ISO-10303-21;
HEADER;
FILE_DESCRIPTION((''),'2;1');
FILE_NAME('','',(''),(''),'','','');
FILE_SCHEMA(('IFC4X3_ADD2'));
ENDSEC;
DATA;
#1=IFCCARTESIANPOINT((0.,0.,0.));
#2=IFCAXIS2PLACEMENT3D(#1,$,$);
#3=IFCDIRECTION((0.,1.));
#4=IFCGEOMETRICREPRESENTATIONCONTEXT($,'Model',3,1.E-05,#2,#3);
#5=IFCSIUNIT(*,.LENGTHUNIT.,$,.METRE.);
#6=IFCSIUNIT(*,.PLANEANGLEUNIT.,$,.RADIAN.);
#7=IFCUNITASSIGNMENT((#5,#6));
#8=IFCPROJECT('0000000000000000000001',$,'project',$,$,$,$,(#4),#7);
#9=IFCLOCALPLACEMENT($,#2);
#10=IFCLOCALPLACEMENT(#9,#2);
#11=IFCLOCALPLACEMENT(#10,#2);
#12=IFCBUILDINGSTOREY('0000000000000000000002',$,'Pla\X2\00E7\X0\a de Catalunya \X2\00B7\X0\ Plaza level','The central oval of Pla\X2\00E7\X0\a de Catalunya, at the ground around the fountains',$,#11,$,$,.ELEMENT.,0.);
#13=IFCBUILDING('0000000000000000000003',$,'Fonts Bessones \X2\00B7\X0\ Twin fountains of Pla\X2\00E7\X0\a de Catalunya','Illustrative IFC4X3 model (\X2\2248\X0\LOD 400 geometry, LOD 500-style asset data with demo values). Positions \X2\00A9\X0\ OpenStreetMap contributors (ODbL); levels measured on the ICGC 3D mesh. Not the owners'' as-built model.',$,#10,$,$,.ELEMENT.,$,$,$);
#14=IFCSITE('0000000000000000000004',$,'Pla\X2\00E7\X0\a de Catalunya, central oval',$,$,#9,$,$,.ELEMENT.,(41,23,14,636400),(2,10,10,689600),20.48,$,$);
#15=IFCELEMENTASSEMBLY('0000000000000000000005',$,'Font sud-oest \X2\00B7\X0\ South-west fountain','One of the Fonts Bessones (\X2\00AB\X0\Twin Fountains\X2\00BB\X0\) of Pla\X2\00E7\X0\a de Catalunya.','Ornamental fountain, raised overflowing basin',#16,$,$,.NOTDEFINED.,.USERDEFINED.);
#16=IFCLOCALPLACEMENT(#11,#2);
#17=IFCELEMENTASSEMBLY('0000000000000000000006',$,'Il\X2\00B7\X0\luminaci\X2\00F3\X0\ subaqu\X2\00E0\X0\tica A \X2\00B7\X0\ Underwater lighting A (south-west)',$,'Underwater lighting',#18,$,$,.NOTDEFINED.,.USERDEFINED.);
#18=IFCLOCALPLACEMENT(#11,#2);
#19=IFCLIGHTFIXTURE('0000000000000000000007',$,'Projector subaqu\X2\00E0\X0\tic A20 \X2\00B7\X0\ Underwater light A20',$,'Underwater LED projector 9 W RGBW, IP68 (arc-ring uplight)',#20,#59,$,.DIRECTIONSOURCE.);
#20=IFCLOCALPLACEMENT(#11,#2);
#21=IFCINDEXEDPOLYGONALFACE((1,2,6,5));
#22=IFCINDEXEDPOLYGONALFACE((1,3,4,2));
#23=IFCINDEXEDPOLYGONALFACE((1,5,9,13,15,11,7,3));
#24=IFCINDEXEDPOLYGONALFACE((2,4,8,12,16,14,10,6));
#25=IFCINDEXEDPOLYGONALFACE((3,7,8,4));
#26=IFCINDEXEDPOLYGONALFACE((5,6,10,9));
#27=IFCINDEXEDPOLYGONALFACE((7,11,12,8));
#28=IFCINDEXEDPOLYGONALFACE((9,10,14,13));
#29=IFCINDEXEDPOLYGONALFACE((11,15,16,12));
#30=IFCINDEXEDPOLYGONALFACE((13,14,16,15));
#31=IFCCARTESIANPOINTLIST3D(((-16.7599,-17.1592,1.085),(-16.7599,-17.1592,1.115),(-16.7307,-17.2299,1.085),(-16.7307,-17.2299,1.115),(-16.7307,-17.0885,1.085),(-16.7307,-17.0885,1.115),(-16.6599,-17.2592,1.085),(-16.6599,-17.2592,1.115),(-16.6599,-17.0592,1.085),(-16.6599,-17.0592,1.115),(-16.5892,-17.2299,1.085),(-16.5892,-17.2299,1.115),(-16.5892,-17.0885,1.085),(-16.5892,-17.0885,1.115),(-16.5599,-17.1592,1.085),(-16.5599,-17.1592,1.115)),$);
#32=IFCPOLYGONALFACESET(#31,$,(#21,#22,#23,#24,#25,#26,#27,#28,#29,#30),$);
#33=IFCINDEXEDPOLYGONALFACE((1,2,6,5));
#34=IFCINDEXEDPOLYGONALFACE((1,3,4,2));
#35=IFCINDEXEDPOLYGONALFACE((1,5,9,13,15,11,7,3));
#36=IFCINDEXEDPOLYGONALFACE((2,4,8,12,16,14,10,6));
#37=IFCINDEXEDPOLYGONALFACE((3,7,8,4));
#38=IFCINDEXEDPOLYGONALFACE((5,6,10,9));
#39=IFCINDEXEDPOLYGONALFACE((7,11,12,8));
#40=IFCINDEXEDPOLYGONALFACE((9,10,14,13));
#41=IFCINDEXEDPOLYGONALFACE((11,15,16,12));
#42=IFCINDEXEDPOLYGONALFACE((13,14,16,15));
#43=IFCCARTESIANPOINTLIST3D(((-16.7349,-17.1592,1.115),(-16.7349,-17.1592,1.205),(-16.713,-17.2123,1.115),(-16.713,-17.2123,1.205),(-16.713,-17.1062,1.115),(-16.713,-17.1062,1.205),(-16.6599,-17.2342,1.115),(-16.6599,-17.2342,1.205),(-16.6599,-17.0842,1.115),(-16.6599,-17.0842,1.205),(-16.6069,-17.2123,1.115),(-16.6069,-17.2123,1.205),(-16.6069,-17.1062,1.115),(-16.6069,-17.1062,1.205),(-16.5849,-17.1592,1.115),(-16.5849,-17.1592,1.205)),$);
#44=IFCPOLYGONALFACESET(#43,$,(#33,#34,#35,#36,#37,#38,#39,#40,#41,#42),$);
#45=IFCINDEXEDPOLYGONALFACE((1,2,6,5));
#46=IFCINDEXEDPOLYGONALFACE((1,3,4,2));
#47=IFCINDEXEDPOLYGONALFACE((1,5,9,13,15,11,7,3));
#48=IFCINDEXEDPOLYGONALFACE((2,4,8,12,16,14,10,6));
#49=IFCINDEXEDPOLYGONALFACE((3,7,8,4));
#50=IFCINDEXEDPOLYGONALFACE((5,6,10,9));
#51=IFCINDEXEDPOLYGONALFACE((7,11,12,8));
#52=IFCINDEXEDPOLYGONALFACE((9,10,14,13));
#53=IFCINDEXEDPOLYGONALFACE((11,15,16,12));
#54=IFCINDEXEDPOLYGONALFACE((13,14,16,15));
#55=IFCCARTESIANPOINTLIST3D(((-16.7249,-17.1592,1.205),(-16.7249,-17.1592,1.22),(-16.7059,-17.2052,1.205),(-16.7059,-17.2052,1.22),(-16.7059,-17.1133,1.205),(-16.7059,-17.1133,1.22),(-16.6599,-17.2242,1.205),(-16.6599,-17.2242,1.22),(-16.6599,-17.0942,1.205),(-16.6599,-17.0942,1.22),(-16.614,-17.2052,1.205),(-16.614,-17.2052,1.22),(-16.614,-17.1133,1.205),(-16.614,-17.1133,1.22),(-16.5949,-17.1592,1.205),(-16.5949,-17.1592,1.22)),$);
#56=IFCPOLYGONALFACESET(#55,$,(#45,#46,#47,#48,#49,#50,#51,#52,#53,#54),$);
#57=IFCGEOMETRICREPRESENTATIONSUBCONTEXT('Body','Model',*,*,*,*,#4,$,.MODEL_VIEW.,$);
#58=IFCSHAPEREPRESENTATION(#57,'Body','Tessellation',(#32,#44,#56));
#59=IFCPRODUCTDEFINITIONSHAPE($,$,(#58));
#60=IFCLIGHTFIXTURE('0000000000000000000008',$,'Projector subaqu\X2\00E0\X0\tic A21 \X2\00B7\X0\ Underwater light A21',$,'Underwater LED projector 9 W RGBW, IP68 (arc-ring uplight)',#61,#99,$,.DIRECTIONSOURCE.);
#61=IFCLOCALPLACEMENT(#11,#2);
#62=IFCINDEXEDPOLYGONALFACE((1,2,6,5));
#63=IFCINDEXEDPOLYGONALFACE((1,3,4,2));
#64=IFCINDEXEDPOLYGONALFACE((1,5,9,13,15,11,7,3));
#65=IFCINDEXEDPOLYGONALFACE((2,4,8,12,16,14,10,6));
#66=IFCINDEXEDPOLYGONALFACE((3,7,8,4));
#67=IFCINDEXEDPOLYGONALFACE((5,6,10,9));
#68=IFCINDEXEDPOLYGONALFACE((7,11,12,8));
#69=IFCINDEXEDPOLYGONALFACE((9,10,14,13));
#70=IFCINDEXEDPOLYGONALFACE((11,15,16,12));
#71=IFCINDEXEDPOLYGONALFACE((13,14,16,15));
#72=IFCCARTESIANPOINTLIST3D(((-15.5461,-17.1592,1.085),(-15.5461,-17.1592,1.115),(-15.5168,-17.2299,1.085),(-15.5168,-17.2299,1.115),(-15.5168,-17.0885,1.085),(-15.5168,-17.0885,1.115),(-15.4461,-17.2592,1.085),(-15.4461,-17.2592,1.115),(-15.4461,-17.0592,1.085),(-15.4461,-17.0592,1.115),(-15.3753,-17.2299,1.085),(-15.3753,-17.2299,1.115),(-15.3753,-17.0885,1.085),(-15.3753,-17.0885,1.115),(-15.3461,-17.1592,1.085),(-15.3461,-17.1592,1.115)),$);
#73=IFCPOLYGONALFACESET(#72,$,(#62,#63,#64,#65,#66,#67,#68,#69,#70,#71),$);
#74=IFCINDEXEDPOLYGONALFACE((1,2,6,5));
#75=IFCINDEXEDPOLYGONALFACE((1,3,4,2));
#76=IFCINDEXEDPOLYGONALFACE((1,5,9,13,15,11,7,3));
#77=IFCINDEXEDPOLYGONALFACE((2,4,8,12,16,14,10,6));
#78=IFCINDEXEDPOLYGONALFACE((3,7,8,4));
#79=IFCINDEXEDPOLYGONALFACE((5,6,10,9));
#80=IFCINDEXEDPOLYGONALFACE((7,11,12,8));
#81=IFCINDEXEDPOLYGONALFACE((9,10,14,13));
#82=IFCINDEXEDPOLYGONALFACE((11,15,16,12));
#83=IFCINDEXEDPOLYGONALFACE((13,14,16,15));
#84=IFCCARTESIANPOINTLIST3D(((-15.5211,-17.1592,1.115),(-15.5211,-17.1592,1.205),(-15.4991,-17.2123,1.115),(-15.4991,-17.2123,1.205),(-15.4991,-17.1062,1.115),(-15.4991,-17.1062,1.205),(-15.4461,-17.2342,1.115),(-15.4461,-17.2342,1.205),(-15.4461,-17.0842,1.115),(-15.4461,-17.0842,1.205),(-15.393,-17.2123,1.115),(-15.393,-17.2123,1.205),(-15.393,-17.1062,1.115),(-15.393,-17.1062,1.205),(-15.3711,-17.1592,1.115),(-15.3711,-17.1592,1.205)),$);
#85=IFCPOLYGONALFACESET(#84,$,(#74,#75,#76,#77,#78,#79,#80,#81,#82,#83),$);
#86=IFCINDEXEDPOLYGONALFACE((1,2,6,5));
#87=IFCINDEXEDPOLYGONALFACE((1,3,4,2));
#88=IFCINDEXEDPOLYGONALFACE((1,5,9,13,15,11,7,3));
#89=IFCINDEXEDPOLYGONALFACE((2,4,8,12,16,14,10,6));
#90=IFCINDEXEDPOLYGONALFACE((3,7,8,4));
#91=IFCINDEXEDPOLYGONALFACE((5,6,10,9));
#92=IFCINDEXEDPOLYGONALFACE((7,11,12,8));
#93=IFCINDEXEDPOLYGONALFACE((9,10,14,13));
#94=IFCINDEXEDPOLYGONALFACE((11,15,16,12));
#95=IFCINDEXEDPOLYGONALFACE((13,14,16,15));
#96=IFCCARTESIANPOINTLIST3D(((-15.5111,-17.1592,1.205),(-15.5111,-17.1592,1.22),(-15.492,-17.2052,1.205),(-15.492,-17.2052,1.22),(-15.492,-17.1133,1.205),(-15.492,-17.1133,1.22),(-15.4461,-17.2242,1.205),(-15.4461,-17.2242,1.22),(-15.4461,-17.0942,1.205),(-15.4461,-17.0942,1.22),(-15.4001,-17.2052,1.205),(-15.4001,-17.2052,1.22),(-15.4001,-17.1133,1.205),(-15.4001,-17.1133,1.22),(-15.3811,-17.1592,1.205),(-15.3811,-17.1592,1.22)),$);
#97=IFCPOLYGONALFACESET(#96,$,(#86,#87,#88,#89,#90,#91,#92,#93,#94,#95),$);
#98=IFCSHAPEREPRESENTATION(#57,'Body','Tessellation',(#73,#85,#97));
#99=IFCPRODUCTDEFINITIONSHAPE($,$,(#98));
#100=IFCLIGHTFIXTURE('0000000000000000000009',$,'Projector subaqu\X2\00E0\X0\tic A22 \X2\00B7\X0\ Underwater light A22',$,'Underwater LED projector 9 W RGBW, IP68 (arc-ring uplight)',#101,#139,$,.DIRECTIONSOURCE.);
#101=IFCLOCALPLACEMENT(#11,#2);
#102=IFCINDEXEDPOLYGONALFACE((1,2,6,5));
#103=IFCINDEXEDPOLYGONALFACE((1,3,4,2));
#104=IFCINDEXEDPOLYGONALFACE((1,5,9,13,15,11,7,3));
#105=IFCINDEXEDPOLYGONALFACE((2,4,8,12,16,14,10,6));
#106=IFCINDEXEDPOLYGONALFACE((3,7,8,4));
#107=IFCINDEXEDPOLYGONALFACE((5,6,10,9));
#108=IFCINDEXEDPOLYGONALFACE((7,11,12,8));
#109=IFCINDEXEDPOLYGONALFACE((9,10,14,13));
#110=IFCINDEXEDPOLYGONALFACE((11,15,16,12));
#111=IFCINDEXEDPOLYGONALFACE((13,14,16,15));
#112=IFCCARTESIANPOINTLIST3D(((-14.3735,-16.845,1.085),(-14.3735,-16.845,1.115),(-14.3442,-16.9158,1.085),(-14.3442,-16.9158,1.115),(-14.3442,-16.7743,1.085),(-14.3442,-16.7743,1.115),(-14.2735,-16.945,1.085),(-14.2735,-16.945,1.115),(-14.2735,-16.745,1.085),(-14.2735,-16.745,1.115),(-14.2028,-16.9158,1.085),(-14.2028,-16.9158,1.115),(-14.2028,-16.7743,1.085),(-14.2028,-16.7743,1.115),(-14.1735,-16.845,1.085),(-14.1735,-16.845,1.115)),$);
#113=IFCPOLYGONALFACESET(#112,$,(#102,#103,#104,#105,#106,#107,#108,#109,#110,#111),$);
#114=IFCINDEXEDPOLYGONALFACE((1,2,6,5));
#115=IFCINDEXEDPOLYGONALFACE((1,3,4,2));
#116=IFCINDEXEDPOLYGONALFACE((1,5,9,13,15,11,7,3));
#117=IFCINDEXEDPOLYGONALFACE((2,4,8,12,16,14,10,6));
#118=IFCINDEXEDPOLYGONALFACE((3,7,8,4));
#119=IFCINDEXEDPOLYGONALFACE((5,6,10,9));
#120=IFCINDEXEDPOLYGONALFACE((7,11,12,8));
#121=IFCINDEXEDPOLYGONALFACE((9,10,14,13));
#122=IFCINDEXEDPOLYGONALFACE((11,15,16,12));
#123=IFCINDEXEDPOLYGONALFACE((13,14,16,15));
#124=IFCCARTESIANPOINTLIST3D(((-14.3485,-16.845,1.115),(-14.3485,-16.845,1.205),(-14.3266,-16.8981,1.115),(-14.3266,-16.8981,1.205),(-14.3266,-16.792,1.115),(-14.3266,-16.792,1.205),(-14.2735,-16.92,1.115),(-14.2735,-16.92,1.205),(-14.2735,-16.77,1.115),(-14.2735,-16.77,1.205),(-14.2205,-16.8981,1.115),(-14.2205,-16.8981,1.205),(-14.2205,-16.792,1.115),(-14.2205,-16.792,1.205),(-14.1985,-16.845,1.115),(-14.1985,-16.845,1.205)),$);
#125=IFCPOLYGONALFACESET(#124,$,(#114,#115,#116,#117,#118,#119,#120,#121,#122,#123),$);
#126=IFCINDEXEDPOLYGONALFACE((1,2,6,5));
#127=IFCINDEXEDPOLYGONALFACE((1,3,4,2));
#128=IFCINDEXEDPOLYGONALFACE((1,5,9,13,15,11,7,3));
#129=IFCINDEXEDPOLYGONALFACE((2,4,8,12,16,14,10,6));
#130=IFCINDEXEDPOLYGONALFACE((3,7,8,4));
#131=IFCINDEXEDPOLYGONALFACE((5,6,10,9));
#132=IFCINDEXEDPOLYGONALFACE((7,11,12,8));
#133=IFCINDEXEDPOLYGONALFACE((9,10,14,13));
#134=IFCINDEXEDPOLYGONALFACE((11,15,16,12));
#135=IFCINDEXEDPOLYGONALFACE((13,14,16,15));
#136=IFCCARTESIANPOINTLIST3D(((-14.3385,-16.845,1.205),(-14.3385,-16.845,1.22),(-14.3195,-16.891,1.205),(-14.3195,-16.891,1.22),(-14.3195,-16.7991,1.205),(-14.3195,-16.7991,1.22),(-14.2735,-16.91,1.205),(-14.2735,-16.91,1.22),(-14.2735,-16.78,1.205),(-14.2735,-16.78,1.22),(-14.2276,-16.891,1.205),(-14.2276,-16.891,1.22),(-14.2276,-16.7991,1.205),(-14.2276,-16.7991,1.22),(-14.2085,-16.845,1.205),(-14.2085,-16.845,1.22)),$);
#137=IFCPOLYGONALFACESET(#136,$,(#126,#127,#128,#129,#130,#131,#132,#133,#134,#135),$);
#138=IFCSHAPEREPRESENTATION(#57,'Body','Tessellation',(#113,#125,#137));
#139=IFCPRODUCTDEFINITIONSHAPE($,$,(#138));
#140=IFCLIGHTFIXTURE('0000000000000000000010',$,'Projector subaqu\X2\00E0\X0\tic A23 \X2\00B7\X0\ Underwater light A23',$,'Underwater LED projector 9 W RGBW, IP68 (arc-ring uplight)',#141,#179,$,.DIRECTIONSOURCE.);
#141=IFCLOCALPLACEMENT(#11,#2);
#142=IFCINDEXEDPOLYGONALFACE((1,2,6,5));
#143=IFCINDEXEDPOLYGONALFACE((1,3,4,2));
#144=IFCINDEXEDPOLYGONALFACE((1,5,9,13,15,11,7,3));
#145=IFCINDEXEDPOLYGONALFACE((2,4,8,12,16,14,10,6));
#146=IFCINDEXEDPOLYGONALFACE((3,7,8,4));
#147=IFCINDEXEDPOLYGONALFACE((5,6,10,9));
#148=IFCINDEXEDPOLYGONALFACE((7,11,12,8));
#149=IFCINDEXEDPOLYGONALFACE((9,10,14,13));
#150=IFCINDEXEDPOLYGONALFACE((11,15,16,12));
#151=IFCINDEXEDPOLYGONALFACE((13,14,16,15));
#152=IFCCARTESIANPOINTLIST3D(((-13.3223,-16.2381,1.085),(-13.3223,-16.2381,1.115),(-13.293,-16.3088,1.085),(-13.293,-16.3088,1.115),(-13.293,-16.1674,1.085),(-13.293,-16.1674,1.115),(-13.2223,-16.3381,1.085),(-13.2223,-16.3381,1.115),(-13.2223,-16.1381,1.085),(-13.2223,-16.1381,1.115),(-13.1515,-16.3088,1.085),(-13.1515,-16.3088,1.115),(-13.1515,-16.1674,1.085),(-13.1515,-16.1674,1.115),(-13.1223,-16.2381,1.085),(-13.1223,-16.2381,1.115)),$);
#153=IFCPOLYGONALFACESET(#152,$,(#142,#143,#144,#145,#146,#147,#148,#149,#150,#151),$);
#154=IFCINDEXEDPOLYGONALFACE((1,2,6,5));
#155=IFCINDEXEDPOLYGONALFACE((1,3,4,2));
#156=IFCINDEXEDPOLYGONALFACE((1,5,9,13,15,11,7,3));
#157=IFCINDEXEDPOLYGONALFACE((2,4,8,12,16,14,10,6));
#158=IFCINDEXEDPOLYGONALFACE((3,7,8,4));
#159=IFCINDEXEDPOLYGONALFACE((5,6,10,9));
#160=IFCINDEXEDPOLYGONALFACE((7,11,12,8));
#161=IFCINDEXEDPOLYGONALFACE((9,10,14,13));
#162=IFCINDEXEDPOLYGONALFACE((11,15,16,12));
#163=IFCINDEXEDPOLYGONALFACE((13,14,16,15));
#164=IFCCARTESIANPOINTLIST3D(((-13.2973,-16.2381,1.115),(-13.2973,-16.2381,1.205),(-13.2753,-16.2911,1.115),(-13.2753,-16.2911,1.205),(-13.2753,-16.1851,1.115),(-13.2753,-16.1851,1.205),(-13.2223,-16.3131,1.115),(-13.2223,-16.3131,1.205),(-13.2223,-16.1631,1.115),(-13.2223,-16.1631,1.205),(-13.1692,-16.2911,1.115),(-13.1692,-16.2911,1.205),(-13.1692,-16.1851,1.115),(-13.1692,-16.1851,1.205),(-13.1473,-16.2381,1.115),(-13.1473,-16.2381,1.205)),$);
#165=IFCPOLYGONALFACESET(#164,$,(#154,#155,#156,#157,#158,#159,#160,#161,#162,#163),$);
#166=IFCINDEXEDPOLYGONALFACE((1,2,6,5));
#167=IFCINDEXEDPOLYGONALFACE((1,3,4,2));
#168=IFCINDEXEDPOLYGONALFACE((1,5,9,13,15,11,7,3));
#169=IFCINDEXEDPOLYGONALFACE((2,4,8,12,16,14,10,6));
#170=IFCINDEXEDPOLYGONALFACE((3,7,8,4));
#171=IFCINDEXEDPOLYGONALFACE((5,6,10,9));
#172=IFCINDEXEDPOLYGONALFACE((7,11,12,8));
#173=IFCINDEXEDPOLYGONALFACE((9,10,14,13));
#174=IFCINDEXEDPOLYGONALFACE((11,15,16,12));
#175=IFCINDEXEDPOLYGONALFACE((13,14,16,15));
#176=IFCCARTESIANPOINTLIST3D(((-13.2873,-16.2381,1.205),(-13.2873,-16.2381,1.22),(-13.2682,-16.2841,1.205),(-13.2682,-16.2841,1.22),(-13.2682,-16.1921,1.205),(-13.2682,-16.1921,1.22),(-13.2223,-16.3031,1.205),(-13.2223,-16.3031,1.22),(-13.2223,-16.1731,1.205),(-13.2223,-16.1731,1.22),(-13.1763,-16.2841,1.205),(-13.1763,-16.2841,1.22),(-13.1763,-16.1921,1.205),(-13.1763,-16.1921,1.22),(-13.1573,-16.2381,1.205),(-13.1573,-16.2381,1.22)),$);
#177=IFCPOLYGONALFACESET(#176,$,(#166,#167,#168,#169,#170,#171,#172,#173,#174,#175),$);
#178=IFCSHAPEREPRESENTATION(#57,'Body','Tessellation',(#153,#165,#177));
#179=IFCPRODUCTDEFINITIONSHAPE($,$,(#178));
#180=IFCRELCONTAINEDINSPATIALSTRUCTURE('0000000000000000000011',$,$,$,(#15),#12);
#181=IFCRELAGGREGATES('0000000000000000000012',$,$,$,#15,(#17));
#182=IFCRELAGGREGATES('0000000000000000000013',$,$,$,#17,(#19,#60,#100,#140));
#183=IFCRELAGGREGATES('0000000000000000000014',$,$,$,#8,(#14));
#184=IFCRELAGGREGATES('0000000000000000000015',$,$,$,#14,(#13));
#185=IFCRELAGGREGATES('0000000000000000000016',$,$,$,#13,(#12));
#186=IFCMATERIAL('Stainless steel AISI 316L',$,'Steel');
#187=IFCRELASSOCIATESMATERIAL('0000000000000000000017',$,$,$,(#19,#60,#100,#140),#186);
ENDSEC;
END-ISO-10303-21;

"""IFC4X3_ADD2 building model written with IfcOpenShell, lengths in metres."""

from ifc_helpers import new_model, si_unit, direction, frame, origin, place, context, subcontext, project, spatial, polyline, outline, extrude, material, element, aggregate, save


model = new_model("IFC4X3_ADD2")

# Units and contexts
model_context = context("Model", 3, precision=1e-05, world=origin(), true_north=direction((0.0, 1.0)))
body_context = subcontext(model_context, "Body", "Model", "MODEL_VIEW")
ifc_project = project(units=[si_unit("LENGTHUNIT", "METRE"), si_unit("PLANEANGLEUNIT", "RADIAN")], contexts=[model_context])

# Site, building, storey
site_placement = place(None, origin())
site = spatial("IfcSite", under=ifc_project, at=site_placement, Name="Plaça de Catalunya, central oval", CompositionType="ELEMENT", RefLatitude=(41, 23, 14, 636400), RefLongitude=(2, 10, 10, 689600), RefElevation=20.48)
building_placement = place(site_placement, origin())
building = spatial("IfcBuilding", under=site, at=building_placement, Name="Fonts Bessones · Twin fountains of Plaça de Catalunya", Description="Illustrative IFC4X3 model (≈LOD 400 geometry, LOD 500-style asset data with demo values). Positions © OpenStreetMap contributors (ODbL); levels measured on the ICGC 3D mesh. Not the owners' as-built model.", CompositionType="ELEMENT")
storey_placement = place(building_placement, origin())
storey = spatial("IfcBuildingStorey", under=building, at=storey_placement, Name="Plaça de Catalunya · Plaza level", Description="The central oval of Plaça de Catalunya, at the ground around the fountains", CompositionType="ELEMENT", Elevation=0.0)

# Element assemblies, light fixtures
assembly_1_placement = place(building_placement, origin())
assembly_1 = element("IfcElementAssembly", 1, at=assembly_1_placement, inside=storey, Name="Font sud-oest · South-west fountain", Description="One of the Fonts Bessones («Twin Fountains») of Plaça de Catalunya.", ObjectType="Ornamental fountain, raised overflowing basin", AssemblyPlace="NOTDEFINED", PredefinedType="USERDEFINED")
assembly_2_placement = place(building_placement, origin())
assembly_2 = element("IfcElementAssembly", 2, at=assembly_2_placement, Name="Il·luminació subaquàtica A · Underwater lighting A (south-west)", ObjectType="Underwater lighting", AssemblyPlace="NOTDEFINED", PredefinedType="USERDEFINED")
aggregate(assembly_1, [assembly_2])
ifc_material_1 = material(Name="Stainless steel AISI 316L", Category="Steel")
light_fixture_1_placement = place(building_placement, origin())
light_fixture_1 = element("IfcLightFixture", 3, at=light_fixture_1_placement, material=ifc_material_1, Name="Projector subaquàtic A20 · Underwater light A20", ObjectType="Underwater LED projector 9 W RGBW, IP68 (arc-ring uplight)", PredefinedType="DIRECTIONSOURCE", context=body_context, shape_type="SweptSolid", body=[
    extrude(outline(polyline([(-16.5599, -17.1592), (-16.5892, -17.0885), (-16.6599, -17.0592), (-16.7307, -17.0885), (-16.7599, -17.1592), (-16.7307, -17.2299), (-16.6599, -17.2592), (-16.5892, -17.2299), (-16.5599, -17.1592)])), frame((0.0, 0.0, 1.085)), (0.0, 0.0, 1.0), 0.03),
    extrude(outline(polyline([(-16.5849, -17.1592), (-16.6069, -17.1062), (-16.6599, -17.0842), (-16.713, -17.1062), (-16.7349, -17.1592), (-16.713, -17.2123), (-16.6599, -17.2342), (-16.6069, -17.2123), (-16.5849, -17.1592)])), frame((0.0, 0.0, 1.115)), (0.0, 0.0, 1.0), 0.09),
    extrude(outline(polyline([(-16.5949, -17.1592), (-16.614, -17.1133), (-16.6599, -17.0942), (-16.7059, -17.1133), (-16.7249, -17.1592), (-16.7059, -17.2052), (-16.6599, -17.2242), (-16.614, -17.2052), (-16.5949, -17.1592)])), frame((0.0, 0.0, 1.205)), (0.0, 0.0, 1.0), 0.015),
])
light_fixture_2_placement = place(building_placement, origin())
light_fixture_2 = element("IfcLightFixture", 4, at=light_fixture_2_placement, material=ifc_material_1, Name="Projector subaquàtic A21 · Underwater light A21", ObjectType="Underwater LED projector 9 W RGBW, IP68 (arc-ring uplight)", PredefinedType="DIRECTIONSOURCE", context=body_context, shape_type="SweptSolid", body=[
    extrude(outline(polyline([(-15.3461, -17.1592), (-15.3753, -17.0885), (-15.4461, -17.0592), (-15.5168, -17.0885), (-15.5461, -17.1592), (-15.5168, -17.2299), (-15.4461, -17.2592), (-15.3753, -17.2299), (-15.3461, -17.1592)])), frame((0.0, 0.0, 1.085)), (0.0, 0.0, 1.0), 0.03),
    extrude(outline(polyline([(-15.3711, -17.1592), (-15.393, -17.1062), (-15.4461, -17.0842), (-15.4991, -17.1062), (-15.5211, -17.1592), (-15.4991, -17.2123), (-15.4461, -17.2342), (-15.393, -17.2123), (-15.3711, -17.1592)])), frame((0.0, 0.0, 1.115)), (0.0, 0.0, 1.0), 0.09),
    extrude(outline(polyline([(-15.3811, -17.1592), (-15.4001, -17.1133), (-15.4461, -17.0942), (-15.492, -17.1133), (-15.5111, -17.1592), (-15.492, -17.2052), (-15.4461, -17.2242), (-15.4001, -17.2052), (-15.3811, -17.1592)])), frame((0.0, 0.0, 1.205)), (0.0, 0.0, 1.0), 0.015),
])
light_fixture_3_placement = place(building_placement, origin())
light_fixture_3 = element("IfcLightFixture", 5, at=light_fixture_3_placement, material=ifc_material_1, Name="Projector subaquàtic A22 · Underwater light A22", ObjectType="Underwater LED projector 9 W RGBW, IP68 (arc-ring uplight)", PredefinedType="DIRECTIONSOURCE", context=body_context, shape_type="SweptSolid", body=[
    extrude(outline(polyline([(-14.1735, -16.845), (-14.2028, -16.7743), (-14.2735, -16.745), (-14.3442, -16.7743), (-14.3735, -16.845), (-14.3442, -16.9158), (-14.2735, -16.945), (-14.2028, -16.9158), (-14.1735, -16.845)])), frame((0.0, 0.0, 1.085)), (0.0, 0.0, 1.0), 0.03),
    extrude(outline(polyline([(-14.1985, -16.845), (-14.2205, -16.792), (-14.2735, -16.77), (-14.3266, -16.792), (-14.3485, -16.845), (-14.3266, -16.8981), (-14.2735, -16.92), (-14.2205, -16.8981), (-14.1985, -16.845)])), frame((0.0, 0.0, 1.115)), (0.0, 0.0, 1.0), 0.09),
    extrude(outline(polyline([(-14.2085, -16.845), (-14.2276, -16.7991), (-14.2735, -16.78), (-14.3195, -16.7991), (-14.3385, -16.845), (-14.3195, -16.891), (-14.2735, -16.91), (-14.2276, -16.891), (-14.2085, -16.845)])), frame((0.0, 0.0, 1.205)), (0.0, 0.0, 1.0), 0.015),
])
light_fixture_4_placement = place(building_placement, origin())
light_fixture_4 = element("IfcLightFixture", 6, at=light_fixture_4_placement, material=ifc_material_1, Name="Projector subaquàtic A23 · Underwater light A23", ObjectType="Underwater LED projector 9 W RGBW, IP68 (arc-ring uplight)", PredefinedType="DIRECTIONSOURCE", context=body_context, shape_type="SweptSolid", body=[
    extrude(outline(polyline([(-13.1223, -16.2381), (-13.1515, -16.1674), (-13.2223, -16.1381), (-13.293, -16.1674), (-13.3223, -16.2381), (-13.293, -16.3088), (-13.2223, -16.3381), (-13.1515, -16.3088), (-13.1223, -16.2381)])), frame((0.0, 0.0, 1.085)), (0.0, 0.0, 1.0), 0.03),
    extrude(outline(polyline([(-13.1473, -16.2381), (-13.1692, -16.1851), (-13.2223, -16.1631), (-13.2753, -16.1851), (-13.2973, -16.2381), (-13.2753, -16.2911), (-13.2223, -16.3131), (-13.1692, -16.2911), (-13.1473, -16.2381)])), frame((0.0, 0.0, 1.115)), (0.0, 0.0, 1.0), 0.09),
    extrude(outline(polyline([(-13.1573, -16.2381), (-13.1763, -16.1921), (-13.2223, -16.1731), (-13.2682, -16.1921), (-13.2873, -16.2381), (-13.2682, -16.2841), (-13.2223, -16.3031), (-13.1763, -16.2841), (-13.1573, -16.2381)])), frame((0.0, 0.0, 1.205)), (0.0, 0.0, 1.0), 0.015),
])
aggregate(assembly_2, [light_fixture_1, light_fixture_2, light_fixture_3, light_fixture_4])

save(model, "model.ifc")
